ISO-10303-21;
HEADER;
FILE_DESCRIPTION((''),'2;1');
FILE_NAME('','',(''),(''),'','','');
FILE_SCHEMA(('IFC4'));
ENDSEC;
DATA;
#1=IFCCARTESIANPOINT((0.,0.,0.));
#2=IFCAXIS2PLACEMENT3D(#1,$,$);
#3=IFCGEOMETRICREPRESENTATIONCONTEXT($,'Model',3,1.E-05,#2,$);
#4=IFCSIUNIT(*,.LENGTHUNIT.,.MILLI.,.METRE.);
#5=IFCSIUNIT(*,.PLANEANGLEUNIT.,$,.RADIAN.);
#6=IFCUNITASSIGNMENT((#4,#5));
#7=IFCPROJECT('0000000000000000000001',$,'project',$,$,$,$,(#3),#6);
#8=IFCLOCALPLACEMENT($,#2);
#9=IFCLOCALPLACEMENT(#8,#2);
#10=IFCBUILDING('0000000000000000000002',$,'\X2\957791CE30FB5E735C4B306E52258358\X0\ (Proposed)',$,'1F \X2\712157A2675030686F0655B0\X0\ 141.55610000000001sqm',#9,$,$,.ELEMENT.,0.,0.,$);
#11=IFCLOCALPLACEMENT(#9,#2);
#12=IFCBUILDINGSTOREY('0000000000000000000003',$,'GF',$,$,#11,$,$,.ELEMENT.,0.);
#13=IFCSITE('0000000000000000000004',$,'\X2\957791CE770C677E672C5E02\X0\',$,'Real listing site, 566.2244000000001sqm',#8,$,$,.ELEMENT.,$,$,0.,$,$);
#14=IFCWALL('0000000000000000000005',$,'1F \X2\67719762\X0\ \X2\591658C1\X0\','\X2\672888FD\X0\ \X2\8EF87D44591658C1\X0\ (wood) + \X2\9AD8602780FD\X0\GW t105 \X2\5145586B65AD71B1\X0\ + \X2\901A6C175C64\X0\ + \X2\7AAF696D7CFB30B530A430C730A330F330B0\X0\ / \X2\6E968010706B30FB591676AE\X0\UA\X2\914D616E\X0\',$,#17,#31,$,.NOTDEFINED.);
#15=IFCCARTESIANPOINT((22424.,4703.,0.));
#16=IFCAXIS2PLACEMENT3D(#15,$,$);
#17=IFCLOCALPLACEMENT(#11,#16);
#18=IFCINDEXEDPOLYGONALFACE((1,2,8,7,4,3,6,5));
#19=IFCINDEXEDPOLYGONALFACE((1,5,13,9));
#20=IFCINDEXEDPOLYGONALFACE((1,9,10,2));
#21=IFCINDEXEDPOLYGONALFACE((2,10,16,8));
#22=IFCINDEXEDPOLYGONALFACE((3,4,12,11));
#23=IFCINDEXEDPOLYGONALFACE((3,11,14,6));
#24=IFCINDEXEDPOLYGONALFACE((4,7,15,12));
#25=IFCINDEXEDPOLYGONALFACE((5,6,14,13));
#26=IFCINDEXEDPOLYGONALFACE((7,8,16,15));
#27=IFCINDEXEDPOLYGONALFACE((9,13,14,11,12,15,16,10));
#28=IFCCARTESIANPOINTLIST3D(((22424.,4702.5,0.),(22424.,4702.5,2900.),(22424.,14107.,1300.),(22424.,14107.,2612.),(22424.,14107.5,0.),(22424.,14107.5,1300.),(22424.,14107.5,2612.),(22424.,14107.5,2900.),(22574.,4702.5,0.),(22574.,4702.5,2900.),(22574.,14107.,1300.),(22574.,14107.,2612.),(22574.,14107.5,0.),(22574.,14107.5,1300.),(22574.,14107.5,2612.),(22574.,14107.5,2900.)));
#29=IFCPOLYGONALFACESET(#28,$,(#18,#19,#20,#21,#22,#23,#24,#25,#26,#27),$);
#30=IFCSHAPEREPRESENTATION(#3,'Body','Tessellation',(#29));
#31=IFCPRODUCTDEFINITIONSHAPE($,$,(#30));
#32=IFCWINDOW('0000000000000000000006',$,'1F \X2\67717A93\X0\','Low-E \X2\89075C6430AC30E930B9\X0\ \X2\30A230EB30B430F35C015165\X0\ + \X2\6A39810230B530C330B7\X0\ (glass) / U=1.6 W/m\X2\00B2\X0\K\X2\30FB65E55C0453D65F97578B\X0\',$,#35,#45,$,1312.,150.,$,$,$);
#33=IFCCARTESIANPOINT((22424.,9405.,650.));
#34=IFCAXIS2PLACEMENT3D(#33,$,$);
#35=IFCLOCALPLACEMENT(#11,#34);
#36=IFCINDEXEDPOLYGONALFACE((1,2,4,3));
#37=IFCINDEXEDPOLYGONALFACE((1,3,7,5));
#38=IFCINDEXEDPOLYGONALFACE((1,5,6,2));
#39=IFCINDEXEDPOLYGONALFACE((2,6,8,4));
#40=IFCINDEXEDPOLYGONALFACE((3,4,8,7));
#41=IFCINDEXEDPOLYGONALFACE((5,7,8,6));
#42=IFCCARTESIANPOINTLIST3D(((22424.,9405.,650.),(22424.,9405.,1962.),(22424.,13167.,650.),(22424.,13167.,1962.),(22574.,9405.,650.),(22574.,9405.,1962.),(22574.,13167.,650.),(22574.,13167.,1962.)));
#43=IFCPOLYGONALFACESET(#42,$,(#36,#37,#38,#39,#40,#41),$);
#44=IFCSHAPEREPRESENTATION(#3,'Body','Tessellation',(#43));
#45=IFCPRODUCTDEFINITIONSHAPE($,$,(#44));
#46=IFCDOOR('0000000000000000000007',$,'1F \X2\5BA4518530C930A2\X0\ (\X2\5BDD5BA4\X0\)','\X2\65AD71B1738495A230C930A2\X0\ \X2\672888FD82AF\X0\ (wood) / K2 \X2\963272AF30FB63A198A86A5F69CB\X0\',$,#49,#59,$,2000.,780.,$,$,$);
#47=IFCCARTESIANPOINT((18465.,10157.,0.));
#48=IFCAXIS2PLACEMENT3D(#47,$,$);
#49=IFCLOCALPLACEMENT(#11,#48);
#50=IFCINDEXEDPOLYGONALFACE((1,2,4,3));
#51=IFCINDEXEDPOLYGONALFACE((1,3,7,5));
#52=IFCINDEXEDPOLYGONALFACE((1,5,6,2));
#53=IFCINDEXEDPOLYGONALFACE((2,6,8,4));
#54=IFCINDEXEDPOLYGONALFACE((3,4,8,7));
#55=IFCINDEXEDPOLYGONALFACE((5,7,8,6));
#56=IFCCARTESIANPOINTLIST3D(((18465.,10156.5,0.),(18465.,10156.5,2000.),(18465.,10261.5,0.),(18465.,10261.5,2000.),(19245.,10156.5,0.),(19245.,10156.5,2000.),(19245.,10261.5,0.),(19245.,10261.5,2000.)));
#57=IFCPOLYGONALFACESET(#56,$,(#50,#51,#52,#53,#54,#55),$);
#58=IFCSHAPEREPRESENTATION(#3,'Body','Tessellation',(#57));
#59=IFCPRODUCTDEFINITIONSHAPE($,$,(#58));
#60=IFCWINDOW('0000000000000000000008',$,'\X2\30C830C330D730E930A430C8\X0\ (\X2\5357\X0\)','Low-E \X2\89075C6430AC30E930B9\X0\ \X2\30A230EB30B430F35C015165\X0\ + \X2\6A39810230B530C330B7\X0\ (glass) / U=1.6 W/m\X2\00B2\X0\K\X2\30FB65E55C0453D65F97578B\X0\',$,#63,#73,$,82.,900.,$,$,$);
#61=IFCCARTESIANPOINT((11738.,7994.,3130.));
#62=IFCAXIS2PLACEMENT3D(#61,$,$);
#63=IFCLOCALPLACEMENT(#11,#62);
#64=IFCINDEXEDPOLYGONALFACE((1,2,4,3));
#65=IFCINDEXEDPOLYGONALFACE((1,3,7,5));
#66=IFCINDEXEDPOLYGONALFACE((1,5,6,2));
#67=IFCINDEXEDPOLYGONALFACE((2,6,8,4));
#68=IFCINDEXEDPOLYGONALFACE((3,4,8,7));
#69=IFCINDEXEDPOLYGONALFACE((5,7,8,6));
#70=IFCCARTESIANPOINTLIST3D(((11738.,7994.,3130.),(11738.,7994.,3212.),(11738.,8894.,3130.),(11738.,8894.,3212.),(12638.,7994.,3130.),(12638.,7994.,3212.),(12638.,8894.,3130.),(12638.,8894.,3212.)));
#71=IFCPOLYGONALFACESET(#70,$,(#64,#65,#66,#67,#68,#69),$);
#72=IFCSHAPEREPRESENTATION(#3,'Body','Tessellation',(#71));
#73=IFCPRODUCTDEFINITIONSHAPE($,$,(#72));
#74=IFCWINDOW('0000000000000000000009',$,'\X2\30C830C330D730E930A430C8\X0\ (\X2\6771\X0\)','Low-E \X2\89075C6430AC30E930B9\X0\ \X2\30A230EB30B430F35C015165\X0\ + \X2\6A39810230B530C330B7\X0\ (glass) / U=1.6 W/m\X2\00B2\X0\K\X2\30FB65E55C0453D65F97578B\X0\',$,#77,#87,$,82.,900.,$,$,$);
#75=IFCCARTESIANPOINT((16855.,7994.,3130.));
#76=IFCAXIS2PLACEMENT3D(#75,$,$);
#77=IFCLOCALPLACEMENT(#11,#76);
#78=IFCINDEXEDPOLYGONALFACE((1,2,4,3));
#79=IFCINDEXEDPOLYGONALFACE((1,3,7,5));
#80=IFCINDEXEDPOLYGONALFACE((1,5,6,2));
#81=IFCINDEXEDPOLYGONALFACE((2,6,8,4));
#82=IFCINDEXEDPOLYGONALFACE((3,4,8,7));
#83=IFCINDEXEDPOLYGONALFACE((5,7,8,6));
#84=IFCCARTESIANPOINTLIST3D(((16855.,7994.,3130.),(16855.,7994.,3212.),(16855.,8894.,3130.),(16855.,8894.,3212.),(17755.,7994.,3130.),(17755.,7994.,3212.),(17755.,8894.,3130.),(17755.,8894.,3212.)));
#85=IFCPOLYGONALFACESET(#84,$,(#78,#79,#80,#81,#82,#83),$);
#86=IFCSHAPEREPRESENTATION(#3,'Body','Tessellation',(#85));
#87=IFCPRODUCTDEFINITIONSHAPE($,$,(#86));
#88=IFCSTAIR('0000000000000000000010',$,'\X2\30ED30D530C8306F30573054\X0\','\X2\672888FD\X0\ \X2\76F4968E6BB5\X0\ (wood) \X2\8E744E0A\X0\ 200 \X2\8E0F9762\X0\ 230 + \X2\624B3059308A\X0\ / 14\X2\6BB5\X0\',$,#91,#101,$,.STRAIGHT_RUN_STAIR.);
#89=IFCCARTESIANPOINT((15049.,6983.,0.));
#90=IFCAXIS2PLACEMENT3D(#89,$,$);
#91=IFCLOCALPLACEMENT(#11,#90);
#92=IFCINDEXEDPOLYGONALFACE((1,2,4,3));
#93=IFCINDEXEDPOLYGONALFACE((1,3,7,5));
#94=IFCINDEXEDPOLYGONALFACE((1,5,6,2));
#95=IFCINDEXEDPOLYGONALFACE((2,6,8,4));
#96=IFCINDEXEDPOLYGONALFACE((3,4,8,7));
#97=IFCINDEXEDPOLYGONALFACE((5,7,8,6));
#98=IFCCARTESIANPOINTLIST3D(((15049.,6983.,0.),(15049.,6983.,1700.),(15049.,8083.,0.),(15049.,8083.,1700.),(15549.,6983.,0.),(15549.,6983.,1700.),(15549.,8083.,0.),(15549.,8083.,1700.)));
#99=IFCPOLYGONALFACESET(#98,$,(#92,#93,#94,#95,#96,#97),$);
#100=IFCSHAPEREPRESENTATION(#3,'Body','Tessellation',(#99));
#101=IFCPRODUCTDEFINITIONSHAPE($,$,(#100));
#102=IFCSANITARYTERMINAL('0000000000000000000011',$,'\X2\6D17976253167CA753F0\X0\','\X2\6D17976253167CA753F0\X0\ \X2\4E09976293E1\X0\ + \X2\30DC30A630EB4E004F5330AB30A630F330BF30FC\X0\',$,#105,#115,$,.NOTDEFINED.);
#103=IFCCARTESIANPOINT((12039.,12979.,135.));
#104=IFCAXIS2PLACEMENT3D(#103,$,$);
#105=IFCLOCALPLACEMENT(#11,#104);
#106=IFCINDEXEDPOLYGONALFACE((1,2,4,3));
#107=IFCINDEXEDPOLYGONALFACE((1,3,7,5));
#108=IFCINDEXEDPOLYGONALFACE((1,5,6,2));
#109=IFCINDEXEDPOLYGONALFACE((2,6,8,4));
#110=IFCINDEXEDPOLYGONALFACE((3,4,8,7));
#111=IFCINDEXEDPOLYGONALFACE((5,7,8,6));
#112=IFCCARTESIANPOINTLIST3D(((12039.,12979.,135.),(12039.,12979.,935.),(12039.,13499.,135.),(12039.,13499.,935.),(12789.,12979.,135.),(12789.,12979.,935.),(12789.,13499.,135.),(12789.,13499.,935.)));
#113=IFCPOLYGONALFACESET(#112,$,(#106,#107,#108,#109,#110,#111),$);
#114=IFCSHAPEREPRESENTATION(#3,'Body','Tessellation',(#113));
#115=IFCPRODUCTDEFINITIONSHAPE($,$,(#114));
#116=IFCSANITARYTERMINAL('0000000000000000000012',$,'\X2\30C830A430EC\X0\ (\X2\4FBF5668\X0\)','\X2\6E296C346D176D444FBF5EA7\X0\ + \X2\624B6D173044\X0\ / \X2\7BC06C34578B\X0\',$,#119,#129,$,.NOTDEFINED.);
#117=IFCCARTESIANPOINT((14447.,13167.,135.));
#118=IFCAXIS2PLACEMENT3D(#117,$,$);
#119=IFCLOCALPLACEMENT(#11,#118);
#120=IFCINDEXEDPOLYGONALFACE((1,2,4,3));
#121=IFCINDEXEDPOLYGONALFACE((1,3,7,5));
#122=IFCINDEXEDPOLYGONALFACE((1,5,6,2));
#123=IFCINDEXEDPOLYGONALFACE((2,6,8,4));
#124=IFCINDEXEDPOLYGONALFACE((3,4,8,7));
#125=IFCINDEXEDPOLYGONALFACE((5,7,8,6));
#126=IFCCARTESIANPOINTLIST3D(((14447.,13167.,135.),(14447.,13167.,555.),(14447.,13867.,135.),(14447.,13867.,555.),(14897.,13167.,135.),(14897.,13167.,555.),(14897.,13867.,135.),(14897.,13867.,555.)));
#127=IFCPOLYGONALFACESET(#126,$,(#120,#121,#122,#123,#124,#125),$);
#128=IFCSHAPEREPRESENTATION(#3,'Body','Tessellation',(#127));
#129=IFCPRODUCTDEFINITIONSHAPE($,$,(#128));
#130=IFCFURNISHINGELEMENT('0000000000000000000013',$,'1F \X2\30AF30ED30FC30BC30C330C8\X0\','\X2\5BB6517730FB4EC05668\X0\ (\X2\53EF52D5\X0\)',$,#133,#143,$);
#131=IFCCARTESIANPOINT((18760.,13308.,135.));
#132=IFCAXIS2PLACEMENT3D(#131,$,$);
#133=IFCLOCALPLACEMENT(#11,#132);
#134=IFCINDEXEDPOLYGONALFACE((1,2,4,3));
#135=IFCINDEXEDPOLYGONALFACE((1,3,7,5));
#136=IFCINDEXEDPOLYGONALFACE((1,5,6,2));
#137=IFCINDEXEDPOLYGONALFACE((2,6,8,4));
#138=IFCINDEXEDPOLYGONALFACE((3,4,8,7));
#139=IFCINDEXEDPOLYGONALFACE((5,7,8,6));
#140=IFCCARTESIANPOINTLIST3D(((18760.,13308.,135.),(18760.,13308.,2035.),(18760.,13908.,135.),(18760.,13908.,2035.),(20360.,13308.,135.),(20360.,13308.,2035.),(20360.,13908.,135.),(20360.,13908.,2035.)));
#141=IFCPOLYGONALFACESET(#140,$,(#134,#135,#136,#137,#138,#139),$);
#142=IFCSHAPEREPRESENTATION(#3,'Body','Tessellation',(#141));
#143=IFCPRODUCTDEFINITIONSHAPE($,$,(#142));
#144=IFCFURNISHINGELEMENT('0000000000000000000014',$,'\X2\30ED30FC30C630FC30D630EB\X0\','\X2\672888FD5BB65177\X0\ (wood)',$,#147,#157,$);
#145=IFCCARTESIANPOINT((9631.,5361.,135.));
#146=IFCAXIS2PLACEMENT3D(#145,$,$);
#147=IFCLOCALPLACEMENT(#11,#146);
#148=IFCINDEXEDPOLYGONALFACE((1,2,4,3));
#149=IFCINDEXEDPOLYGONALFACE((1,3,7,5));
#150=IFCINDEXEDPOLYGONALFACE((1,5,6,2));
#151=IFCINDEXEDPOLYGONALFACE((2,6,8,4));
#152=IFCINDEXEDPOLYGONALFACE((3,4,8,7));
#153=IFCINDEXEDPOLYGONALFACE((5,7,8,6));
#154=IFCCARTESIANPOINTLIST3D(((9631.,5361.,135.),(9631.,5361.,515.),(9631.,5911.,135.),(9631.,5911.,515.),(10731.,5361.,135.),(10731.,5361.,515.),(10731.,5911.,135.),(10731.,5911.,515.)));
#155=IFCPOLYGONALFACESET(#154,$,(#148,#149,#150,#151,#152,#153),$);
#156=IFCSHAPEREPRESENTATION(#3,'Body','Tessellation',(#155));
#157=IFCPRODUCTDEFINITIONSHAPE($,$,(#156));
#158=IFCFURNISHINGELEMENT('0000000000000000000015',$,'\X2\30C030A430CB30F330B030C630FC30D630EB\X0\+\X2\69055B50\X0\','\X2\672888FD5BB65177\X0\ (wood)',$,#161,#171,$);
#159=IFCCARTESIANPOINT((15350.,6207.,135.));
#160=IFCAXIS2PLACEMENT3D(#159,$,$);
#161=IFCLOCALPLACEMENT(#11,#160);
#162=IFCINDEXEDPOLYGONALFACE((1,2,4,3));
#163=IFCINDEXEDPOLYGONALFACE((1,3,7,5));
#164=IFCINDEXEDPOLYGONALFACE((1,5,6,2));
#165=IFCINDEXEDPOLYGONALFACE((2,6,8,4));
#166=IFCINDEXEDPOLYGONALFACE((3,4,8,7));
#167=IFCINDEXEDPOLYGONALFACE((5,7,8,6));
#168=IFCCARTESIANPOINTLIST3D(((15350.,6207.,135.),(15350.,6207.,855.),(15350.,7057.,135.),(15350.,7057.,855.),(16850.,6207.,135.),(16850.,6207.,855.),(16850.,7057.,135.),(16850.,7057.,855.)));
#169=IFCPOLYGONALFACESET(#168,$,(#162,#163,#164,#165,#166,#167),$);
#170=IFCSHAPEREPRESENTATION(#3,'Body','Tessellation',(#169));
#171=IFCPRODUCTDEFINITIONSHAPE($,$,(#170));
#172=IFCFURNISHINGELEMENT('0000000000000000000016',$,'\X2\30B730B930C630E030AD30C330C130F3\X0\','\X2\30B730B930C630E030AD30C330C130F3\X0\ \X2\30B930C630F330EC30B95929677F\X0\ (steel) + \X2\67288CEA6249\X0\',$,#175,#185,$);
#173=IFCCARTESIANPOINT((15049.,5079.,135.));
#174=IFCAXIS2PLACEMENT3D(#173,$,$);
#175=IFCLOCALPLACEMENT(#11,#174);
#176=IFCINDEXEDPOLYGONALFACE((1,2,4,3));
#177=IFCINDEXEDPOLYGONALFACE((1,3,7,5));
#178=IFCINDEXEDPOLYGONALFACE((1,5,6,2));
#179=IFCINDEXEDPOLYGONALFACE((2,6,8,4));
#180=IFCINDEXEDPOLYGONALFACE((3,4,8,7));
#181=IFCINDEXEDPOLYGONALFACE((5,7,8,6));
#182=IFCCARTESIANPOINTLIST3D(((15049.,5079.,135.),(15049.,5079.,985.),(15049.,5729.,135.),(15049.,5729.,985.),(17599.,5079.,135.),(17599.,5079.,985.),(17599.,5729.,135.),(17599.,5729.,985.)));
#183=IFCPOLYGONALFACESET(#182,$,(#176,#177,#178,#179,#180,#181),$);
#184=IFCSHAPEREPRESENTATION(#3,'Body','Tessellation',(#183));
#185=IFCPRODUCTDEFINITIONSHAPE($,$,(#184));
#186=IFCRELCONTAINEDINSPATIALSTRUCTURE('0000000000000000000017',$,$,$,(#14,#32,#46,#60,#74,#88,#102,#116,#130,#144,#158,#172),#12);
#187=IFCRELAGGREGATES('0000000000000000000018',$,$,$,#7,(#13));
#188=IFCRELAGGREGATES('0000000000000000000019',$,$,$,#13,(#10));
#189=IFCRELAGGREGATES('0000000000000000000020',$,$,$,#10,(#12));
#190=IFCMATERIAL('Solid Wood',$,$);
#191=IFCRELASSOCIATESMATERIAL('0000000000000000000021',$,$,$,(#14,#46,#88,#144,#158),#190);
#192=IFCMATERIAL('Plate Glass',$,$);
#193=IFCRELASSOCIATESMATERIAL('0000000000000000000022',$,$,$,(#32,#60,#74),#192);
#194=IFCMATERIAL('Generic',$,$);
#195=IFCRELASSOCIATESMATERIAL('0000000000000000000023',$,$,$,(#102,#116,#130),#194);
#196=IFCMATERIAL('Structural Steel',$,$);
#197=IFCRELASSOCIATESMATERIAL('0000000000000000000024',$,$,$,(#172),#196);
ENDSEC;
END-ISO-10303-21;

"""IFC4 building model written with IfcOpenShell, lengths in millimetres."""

from ifc_helpers import new_model, si_unit, frame, frame_2d, origin, place, context, project, spatial, rectangle, extrude, material, element, fill, save


model = new_model("IFC4")

# Units and contexts
model_context = context("Model", 3, precision=1e-05, world=origin())
ifc_project = project(units=[si_unit("LENGTHUNIT", "METRE", prefix="MILLI"), si_unit("PLANEANGLEUNIT", "RADIAN")], contexts=[model_context])

# Site, building, storey
site_placement = place(None, origin())
site = spatial("IfcSite", under=ifc_project, at=site_placement, Name="長野県松本市", ObjectType="Real listing site, 566.2244000000001sqm", CompositionType="ELEMENT", RefElevation=0.0)
building_placement = place(site_placement, origin())
building = spatial("IfcBuilding", under=site, at=building_placement, Name="長野・平屋の別荘 (Proposed)", ObjectType="1F 無垢材と漆喰 141.55610000000001sqm", CompositionType="ELEMENT", ElevationOfRefHeight=0.0, ElevationOfTerrain=0.0)
storey_placement = place(building_placement, origin())
storey = spatial("IfcBuildingStorey", under=building, at=storey_placement, Name="GF", CompositionType="ELEMENT", Elevation=0.0)

# Wall, opening, window
ifc_material_1 = material(Name="Solid Wood")
wall_1_placement = place(storey_placement, frame((22424.0, 4703.0, 0.0)))
wall_1 = element("IfcWall", 1, at=wall_1_placement, inside=storey, material=ifc_material_1, Name="1F 東面 外壁", Description="木製 軸組外壁 (wood) + 高性能GW t105 充填断熱 + 通気層 + 窯業系サイディング / 準耐火・外皮UA配慮", PredefinedType="NOTDEFINED", context=model_context, shape_type="SweptSolid", body=[
    extrude(rectangle(XDim=150.0, YDim=9405.0, at=frame_2d((75.0, 4702.0))), frame((22424.0, 4703.0, 0.0)), (0.0, 0.0, 1.0), 2900.0),
])
opening_placement = place(storey_placement, frame((22424.0, 9405.0, 650.0)))
opening = element("IfcOpeningElement", 2, at=opening_placement, cuts=wall_1, PredefinedType="NOTDEFINED", context=model_context, shape_type="SweptSolid", body=[
    extrude(rectangle(XDim=150.0, YDim=3762.0, at=frame_2d((75.0, 1881.0))), frame((22424.0, 9405.0, 650.0)), (0.0, 0.0, 1.0), 1312.0),
])
ifc_material_2 = material(Name="Plate Glass")
window_1_placement = place(storey_placement, frame((22424.0, 9405.0, 650.0)))
window_1 = element("IfcWindow", 3, at=window_1_placement, inside=storey, material=ifc_material_2, Name="1F 東窓", Description="Low-E 複層ガラス アルゴン封入 + 樹脂サッシ (glass) / U=1.6 W/m²K・日射取得型", OverallHeight=1312.0, OverallWidth=150.0, context=model_context, shape_type="SweptSolid", body=[
    extrude(rectangle(XDim=150.0, YDim=3762.0, at=frame_2d((75.0, 1881.0))), frame((22424.0, 9405.0, 650.0)), (0.0, 0.0, 1.0), 1312.0),
])
fill(opening, window_1)

# Door
door_placement = place(storey_placement, frame((18465.0, 10157.0, 0.0)))
element("IfcDoor", 4, at=door_placement, inside=storey, material=ifc_material_1, Name="1F 室内ドア (寝室)", Description="断熱玄関ドア 木製芯 (wood) / K2 防犯・採風機構", OverallHeight=2000.0, OverallWidth=780.0, context=model_context, shape_type="SweptSolid", body=[
    extrude(rectangle(XDim=780.0, YDim=105.0, at=frame_2d((390.0, 52.0))), frame((18465.0, 10157.0, 0.0)), (0.0, 0.0, 1.0), 2000.0),
])

# Windows
window_2_placement = place(storey_placement, frame((11738.0, 7994.0, 3130.0)))
element("IfcWindow", 5, at=window_2_placement, inside=storey, material=ifc_material_2, Name="トップライト (南)", Description="Low-E 複層ガラス アルゴン封入 + 樹脂サッシ (glass) / U=1.6 W/m²K・日射取得型", OverallHeight=82.0, OverallWidth=900.0, context=model_context, shape_type="SweptSolid", body=[
    extrude(rectangle(XDim=900.0, YDim=900.0, at=frame_2d((450.0, 450.0))), frame((11738.0, 7994.0, 3130.0)), (0.0, 0.0, 1.0), 82.0),
])
window_3_placement = place(storey_placement, frame((16855.0, 7994.0, 3130.0)))
element("IfcWindow", 6, at=window_3_placement, inside=storey, material=ifc_material_2, Name="トップライト (東)", Description="Low-E 複層ガラス アルゴン封入 + 樹脂サッシ (glass) / U=1.6 W/m²K・日射取得型", OverallHeight=82.0, OverallWidth=900.0, context=model_context, shape_type="SweptSolid", body=[
    extrude(rectangle(XDim=900.0, YDim=900.0, at=frame_2d((450.0, 450.0))), frame((16855.0, 7994.0, 3130.0)), (0.0, 0.0, 1.0), 82.0),
])

# Stair
stair_placement = place(storey_placement, frame((15049.0, 6983.0, 0.0)))
element("IfcStair", 7, at=stair_placement, inside=storey, material=ifc_material_1, Name="ロフトはしご", Description="木製 直階段 (wood) 蹴上 200 踏面 230 + 手すり / 14段", PredefinedType="STRAIGHT_RUN_STAIR", context=model_context, shape_type="SweptSolid", body=[
    extrude(rectangle(XDim=500.0, YDim=1100.0, at=frame_2d((250.0, 550.0))), frame((15049.0, 6983.0, 0.0)), (0.0, 0.0, 1.0), 1700.0),
])

# Sanitary terminals
ifc_material_3 = material(Name="Generic")
sanitary_terminal_1_placement = place(storey_placement, frame((12039.0, 12979.0, 135.0)))
element("IfcSanitaryTerminal", 8, at=sanitary_terminal_1_placement, inside=storey, material=ifc_material_3, Name="洗面化粧台", Description="洗面化粧台 三面鏡 + ボウル一体カウンター", PredefinedType="NOTDEFINED", context=model_context, shape_type="SweptSolid", body=[
    extrude(rectangle(XDim=750.0, YDim=520.0, at=frame_2d((375.0, 260.0))), frame((12039.0, 12979.0, 135.0)), (0.0, 0.0, 1.0), 800.0),
])
sanitary_terminal_2_placement = place(storey_placement, frame((14447.0, 13167.0, 135.0)))
element("IfcSanitaryTerminal", 9, at=sanitary_terminal_2_placement, inside=storey, material=ifc_material_3, Name="トイレ (便器)", Description="温水洗浄便座 + 手洗い / 節水型", PredefinedType="NOTDEFINED", context=model_context, shape_type="SweptSolid", body=[
    extrude(rectangle(XDim=450.0, YDim=700.0, at=frame_2d((225.0, 350.0))), frame((14447.0, 13167.0, 135.0)), (0.0, 0.0, 1.0), 420.0),
])

# Furnishing elements
furnishing_1_placement = place(storey_placement, frame((18760.0, 13308.0, 135.0)))
element("IfcFurnishingElement", 10, at=furnishing_1_placement, inside=storey, material=ifc_material_3, Name="1F クローゼット", Description="家具・什器 (可動)", context=model_context, shape_type="SweptSolid", body=[
    extrude(rectangle(XDim=1600.0, YDim=600.0, at=frame_2d((800.0, 300.0))), frame((18760.0, 13308.0, 135.0)), (0.0, 0.0, 1.0), 1900.0),
])
furnishing_2_placement = place(storey_placement, frame((9631.0, 5361.0, 135.0)))
element("IfcFurnishingElement", 11, at=furnishing_2_placement, inside=storey, material=ifc_material_1, Name="ローテーブル", Description="木製家具 (wood)", context=model_context, shape_type="SweptSolid", body=[
    extrude(rectangle(XDim=1100.0, YDim=550.0, at=frame_2d((550.0, 275.0))), frame((9631.0, 5361.0, 135.0)), (0.0, 0.0, 1.0), 380.0),
])
furnishing_3_placement = place(storey_placement, frame((15350.0, 6207.0, 135.0)))
element("IfcFurnishingElement", 12, at=furnishing_3_placement, inside=storey, material=ifc_material_1, Name="ダイニングテーブル+椅子", Description="木製家具 (wood)", context=model_context, shape_type="SweptSolid", body=[
    extrude(rectangle(XDim=1500.0, YDim=850.0, at=frame_2d((750.0, 425.0))), frame((15350.0, 6207.0, 135.0)), (0.0, 0.0, 1.0), 720.0),
])
ifc_material_4 = material(Name="Structural Steel")
furnishing_4_placement = place(storey_placement, frame((15049.0, 5079.0, 135.0)))
element("IfcFurnishingElement", 13, at=furnishing_4_placement, inside=storey, material=ifc_material_4, Name="システムキッチン", Description="システムキッチン ステンレス天板 (steel) + 木質扉", context=model_context, shape_type="SweptSolid", body=[
    extrude(rectangle(XDim=2550.0, YDim=650.0, at=frame_2d((1275.0, 325.0))), frame((15049.0, 5079.0, 135.0)), (0.0, 0.0, 1.0), 850.0),
])

save(model, "model.ifc")
